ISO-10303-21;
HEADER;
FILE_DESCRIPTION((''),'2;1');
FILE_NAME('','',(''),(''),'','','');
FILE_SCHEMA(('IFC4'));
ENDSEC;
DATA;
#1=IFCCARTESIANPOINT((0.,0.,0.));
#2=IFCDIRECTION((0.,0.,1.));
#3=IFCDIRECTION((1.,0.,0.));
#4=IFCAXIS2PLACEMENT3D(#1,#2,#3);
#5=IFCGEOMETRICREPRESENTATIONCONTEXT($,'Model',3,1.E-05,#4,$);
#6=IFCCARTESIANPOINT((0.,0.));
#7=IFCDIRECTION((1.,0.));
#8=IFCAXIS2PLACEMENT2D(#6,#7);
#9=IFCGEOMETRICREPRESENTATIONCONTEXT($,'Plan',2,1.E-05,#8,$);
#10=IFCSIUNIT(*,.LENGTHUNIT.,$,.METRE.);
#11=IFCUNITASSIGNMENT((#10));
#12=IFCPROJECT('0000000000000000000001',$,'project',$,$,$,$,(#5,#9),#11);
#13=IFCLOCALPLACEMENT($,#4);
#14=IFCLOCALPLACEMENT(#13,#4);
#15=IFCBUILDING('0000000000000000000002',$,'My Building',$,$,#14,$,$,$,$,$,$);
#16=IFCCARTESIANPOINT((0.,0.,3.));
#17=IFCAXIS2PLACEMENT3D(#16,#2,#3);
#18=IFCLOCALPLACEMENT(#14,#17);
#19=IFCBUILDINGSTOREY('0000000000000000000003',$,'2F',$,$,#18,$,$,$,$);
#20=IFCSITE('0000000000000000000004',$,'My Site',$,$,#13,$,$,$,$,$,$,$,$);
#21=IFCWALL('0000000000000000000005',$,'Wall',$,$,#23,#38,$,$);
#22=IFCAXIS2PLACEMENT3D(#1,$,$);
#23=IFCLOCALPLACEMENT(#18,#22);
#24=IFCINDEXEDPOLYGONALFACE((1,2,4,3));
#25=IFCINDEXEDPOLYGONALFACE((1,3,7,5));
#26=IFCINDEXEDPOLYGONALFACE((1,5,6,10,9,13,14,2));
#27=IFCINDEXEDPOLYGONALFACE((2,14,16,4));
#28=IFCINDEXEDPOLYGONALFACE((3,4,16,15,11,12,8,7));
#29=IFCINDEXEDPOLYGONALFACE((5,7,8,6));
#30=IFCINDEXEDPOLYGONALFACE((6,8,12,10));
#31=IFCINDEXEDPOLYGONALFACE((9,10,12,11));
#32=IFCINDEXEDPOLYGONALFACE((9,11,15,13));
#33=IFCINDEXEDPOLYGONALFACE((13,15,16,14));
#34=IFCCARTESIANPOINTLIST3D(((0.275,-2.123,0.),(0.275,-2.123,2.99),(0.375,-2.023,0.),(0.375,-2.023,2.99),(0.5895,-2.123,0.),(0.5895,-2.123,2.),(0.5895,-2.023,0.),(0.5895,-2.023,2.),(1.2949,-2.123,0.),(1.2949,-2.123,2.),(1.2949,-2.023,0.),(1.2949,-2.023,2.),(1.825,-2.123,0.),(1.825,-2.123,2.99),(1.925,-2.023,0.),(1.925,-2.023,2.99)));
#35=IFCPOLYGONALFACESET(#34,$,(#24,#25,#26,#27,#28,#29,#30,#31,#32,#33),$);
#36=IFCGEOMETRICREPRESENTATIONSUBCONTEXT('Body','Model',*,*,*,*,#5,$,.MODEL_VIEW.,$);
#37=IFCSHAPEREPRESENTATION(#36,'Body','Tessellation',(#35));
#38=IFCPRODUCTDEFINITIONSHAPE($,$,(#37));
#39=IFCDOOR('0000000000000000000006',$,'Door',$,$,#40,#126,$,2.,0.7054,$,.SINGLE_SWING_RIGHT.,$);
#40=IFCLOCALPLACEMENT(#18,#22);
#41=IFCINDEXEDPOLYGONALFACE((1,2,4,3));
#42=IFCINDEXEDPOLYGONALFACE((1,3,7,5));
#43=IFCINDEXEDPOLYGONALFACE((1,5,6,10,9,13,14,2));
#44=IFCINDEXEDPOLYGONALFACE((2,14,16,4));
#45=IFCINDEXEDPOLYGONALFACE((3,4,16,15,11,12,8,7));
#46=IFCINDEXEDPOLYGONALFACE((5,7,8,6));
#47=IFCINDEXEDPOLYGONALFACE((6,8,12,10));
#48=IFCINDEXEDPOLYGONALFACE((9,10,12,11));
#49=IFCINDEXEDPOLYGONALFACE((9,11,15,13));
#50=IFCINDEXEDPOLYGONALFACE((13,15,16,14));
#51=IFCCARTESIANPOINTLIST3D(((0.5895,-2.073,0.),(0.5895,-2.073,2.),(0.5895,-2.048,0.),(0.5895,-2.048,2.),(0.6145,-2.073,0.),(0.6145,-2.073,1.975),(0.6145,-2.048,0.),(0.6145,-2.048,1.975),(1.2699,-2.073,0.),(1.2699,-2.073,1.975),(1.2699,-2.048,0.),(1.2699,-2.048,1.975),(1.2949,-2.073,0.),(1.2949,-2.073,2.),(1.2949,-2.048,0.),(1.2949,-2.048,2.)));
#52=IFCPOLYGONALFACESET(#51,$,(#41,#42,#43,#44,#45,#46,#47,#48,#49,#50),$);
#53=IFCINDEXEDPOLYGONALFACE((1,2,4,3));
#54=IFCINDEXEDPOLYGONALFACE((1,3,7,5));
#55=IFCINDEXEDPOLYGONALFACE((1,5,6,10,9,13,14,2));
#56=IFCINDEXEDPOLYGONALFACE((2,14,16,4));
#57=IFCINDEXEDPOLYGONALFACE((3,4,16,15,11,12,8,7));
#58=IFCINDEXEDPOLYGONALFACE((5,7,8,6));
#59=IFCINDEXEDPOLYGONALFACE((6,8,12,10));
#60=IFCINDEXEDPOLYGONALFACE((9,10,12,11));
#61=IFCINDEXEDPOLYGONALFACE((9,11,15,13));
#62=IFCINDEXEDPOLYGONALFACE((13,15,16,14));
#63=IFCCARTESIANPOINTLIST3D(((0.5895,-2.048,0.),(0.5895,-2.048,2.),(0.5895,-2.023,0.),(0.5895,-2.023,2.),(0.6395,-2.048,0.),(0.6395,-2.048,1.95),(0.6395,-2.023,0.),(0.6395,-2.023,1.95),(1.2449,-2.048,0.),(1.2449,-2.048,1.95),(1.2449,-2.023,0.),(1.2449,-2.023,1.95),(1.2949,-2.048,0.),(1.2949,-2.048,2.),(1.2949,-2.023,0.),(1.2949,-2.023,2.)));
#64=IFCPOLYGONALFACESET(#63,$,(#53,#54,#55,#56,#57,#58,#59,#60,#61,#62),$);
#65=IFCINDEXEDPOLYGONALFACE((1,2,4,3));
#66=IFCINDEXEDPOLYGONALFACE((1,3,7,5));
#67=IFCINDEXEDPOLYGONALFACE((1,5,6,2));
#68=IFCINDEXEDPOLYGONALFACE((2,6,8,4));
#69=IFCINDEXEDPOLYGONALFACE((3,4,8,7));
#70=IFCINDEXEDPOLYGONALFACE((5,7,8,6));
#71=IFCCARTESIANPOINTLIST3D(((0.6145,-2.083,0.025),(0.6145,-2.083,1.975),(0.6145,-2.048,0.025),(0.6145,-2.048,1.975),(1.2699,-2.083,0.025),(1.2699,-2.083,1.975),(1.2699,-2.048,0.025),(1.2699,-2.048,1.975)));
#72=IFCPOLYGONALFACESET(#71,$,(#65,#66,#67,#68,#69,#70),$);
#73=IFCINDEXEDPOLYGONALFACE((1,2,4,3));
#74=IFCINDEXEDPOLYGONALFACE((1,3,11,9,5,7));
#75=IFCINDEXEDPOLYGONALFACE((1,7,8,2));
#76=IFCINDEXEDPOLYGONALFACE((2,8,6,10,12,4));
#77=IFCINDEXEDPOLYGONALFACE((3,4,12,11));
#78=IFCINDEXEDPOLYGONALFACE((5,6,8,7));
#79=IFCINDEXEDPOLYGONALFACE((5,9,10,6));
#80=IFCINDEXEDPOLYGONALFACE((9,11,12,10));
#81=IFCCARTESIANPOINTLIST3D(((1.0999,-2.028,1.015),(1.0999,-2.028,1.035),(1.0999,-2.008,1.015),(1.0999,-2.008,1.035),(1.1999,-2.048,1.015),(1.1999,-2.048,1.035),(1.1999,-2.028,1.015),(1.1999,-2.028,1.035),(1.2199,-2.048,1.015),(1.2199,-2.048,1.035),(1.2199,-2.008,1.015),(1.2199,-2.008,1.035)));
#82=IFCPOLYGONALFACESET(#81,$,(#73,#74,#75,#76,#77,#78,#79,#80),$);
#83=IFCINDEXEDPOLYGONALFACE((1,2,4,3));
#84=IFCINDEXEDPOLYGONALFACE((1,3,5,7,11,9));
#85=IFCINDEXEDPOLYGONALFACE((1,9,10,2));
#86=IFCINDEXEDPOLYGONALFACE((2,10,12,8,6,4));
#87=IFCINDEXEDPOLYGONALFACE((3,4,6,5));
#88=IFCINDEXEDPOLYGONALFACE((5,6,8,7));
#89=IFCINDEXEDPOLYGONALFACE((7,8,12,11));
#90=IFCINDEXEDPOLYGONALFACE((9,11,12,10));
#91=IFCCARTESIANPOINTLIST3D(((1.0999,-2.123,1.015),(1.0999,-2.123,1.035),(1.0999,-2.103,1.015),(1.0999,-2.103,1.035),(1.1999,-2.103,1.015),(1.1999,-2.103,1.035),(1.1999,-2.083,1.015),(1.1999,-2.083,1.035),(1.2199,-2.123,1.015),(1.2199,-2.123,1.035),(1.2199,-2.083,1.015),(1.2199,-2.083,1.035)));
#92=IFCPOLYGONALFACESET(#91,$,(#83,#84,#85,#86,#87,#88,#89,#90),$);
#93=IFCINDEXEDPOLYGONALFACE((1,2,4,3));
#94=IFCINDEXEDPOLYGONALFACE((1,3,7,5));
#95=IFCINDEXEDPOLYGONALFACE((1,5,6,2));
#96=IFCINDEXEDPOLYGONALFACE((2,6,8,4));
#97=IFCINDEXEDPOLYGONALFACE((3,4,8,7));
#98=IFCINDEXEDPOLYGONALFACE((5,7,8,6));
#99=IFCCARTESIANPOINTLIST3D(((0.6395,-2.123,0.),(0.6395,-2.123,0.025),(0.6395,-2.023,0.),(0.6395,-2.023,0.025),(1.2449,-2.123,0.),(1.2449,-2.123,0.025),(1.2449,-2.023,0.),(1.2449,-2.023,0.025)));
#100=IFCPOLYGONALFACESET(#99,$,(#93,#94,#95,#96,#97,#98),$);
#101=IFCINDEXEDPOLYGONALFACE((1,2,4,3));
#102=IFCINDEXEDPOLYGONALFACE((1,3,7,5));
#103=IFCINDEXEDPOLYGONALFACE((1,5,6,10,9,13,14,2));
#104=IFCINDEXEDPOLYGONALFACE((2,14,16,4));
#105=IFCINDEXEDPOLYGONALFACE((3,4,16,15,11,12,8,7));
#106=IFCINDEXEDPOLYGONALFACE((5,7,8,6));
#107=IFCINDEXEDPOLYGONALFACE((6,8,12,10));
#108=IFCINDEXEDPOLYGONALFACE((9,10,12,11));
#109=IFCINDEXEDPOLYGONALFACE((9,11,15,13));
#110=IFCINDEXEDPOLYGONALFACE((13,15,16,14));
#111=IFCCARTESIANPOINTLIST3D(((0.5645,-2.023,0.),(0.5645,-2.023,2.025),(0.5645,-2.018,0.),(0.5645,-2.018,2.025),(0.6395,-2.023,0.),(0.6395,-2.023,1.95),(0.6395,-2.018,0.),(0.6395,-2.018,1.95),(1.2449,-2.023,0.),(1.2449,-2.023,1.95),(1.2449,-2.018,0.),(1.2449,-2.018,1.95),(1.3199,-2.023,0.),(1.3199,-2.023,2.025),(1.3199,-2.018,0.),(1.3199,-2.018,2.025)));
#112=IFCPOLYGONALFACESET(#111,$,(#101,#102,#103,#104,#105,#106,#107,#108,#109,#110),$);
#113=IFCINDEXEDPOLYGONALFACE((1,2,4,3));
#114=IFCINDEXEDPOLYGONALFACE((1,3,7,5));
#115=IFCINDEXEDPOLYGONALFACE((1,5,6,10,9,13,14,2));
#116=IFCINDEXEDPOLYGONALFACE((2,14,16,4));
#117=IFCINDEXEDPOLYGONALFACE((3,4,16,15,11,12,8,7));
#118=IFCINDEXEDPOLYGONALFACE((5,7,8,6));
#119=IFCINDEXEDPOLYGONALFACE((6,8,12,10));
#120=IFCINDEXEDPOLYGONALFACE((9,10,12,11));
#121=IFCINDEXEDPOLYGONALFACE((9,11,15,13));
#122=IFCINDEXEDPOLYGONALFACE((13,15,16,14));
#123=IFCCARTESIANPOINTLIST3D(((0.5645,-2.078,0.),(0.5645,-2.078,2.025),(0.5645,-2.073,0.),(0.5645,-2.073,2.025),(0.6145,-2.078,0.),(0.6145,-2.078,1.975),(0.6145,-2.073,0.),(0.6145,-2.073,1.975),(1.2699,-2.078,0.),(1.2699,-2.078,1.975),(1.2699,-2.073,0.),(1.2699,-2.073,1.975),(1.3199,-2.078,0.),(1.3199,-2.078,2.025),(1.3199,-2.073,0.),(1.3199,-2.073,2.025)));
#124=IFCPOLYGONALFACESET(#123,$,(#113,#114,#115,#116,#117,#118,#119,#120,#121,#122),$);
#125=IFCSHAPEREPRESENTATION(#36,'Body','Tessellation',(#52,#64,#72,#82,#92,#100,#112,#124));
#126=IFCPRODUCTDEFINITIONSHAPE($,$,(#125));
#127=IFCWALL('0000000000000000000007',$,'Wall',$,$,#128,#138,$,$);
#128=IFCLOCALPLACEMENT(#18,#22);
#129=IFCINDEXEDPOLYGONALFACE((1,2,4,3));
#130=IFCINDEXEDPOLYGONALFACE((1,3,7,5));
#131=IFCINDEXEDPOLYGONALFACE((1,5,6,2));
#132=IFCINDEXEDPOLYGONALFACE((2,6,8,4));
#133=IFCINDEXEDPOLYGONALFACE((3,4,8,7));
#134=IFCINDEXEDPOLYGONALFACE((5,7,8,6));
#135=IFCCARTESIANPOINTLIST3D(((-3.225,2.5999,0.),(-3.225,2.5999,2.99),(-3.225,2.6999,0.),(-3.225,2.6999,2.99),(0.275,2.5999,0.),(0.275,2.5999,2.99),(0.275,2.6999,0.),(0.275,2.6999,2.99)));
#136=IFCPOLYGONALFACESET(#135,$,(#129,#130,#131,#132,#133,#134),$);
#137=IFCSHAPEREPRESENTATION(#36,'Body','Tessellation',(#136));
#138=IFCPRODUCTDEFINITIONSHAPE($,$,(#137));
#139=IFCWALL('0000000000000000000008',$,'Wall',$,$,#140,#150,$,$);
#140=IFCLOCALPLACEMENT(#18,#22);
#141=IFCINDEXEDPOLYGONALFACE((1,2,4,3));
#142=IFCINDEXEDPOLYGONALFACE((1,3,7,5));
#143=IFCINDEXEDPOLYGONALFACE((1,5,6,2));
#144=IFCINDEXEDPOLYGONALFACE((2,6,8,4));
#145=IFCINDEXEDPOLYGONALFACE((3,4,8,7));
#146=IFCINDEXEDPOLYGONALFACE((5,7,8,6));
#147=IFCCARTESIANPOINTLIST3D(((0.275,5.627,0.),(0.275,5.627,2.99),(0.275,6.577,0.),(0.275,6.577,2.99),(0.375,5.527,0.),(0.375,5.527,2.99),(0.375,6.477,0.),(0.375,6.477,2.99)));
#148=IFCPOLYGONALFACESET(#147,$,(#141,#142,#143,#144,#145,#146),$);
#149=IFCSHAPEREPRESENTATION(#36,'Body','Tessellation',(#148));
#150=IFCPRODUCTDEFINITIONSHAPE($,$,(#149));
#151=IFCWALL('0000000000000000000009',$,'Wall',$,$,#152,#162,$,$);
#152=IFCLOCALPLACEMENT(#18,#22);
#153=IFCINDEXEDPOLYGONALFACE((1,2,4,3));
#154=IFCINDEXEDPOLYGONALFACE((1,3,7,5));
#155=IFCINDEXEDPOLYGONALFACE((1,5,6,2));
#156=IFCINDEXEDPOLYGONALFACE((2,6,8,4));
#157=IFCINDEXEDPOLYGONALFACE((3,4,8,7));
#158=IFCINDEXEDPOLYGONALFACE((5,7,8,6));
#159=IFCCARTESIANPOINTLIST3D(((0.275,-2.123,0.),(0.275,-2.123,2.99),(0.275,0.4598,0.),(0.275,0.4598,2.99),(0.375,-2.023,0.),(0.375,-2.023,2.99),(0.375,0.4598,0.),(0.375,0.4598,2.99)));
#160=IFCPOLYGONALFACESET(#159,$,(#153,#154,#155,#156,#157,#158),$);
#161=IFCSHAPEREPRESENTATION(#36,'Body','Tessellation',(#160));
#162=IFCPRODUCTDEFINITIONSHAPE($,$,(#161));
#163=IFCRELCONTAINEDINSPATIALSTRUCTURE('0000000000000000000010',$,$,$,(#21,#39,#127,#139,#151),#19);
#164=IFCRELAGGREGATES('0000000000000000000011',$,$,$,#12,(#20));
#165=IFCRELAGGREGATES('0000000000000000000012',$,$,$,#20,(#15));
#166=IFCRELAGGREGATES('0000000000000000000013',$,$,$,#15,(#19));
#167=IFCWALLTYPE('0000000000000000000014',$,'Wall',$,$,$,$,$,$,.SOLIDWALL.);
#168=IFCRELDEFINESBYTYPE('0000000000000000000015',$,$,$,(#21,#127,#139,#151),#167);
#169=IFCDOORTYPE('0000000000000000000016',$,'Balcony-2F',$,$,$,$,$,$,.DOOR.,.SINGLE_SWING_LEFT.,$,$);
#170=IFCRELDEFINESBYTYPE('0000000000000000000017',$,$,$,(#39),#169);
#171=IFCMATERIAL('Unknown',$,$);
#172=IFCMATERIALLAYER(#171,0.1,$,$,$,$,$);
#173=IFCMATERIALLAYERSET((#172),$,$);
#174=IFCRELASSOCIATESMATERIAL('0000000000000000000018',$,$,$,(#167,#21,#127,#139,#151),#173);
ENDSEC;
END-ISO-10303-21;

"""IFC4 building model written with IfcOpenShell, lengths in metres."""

from ifc_helpers import new_model, entity, si_unit, frame, origin_with_axes, origin_2d_with_axis, place, context, subcontext, project, spatial, line, indexed_curve, outline, extrude, shape, source, transform, mapped, material, layer, layer_set, layer_usage, type_object, type_shapes, element, fill, save


model = new_model("IFC4")

# Units and contexts
model_context = context("Model", 3, precision=1e-05, world=origin_with_axes())
plan_context = context("Plan", 2, precision=1e-05, world=origin_2d_with_axis())
body_context_1 = subcontext(model_context, "Body", "Model", "MODEL_VIEW")
body_context_2 = subcontext(plan_context, "Body", "Plan", "PLAN_VIEW")
ifc_project = project(units=[si_unit("LENGTHUNIT", "METRE")], contexts=[model_context, plan_context])

# Site, building, storey
site_placement = place(None, origin_with_axes())
site = spatial("IfcSite", under=ifc_project, at=site_placement, Name="My Site")
building_placement = place(site_placement, origin_with_axes())
building = spatial("IfcBuilding", under=site, at=building_placement, Name="My Building")
storey_placement = place(building_placement, frame((0.0, 0.0, 3.0), z_axis=(0.0, 0.0, 1.0), x_axis=(1.0, 0.0, 0.0)))
storey = spatial("IfcBuildingStorey", under=building, at=storey_placement, Name="2F")

# Shared definitions
ifc_material = material(Name="Unknown")

# Shared definitions
ifc_layer_1 = layer(ifc_material, 0.1)
ifc_layer_set_1 = layer_set([ifc_layer_1])
wall_type = type_object("IfcWallType", Name="Wall", PredefinedType="SOLIDWALL", material=ifc_layer_set_1)

# Wall, opening, door
ifc_layer_usage_1 = layer_usage(ifc_layer_set_1, "AXIS2", "POSITIVE", 0.0)
wall_1_placement = place(storey_placement, frame((0.275, -2.123, 0.0), z_axis=(0.0, 0.0, 1.0), x_axis=(1.0, 0.000001, 0.0)))
wall_1 = element("IfcWall", 1, at=wall_1_placement, inside=storey, type_object=wall_type, material=ifc_layer_usage_1, Name="Wall", context=body_context_1, shape_type="SweptSolid", body=[
    extrude(outline(indexed_curve([(0.0, 0.0), (0.1, 0.1), (1.65, 0.1), (1.55, 0.0)], segments=[line(1, 2, 3, 4, 1)])), origin_with_axes(), (0.0, 0.0, 1.0), 2.99),
])
shared_shape_1 = source(origin_with_axes(), body_context_1, "Body", "SweptSolid", [
    extrude(outline(indexed_curve([(0.0, 0.0), (0.7054, 0.0), (0.7054, 2.0), (0.0, 2.0)], segments=[line(1, 2, 3, 4, 1)])), frame((0.0, -0.6, 0.0), z_axis=(0.0, -1.0, 0.0), x_axis=(1.0, 0.0, 0.0)), (0.0, 0.0, -1.0), 1.2),
])
opening_1_placement = place(wall_1_placement, frame((1.0199, 0.1, 0.0), z_axis=(0.0, 0.0, 1.0), x_axis=(-1.0, 0.0, 0.0)))
opening_1 = element("IfcOpeningElement", 2, at=opening_1_placement, cuts=wall_1, PredefinedType="OPENING", context=body_context_1, shape_type="MappedRepresentation", body=[
    mapped(shared_shape_1, transform((0.0, 0.0, 0.0), x_axis=(1.0, 0.0, 0.0), y_axis=(0.0, 1.0, 0.0), z_axis=(0.0, 0.0, 1.0), scale=1.0)),
])
door_type_1 = type_object("IfcDoorType", Name="Balcony-2F", OperationType="SINGLE_SWING_LEFT", PredefinedType="DOOR")
shared_shape_2 = source(origin_with_axes(), body_context_1, "Body", "SweptSolid", [
    extrude(outline(indexed_curve([(0.0, 0.0), (0.0, 2.0), (0.7054, 2.0), (0.7054, 0.0), (0.6804, 0.0), (0.6804, 1.975), (0.025, 1.975), (0.025, 0.0)], segments=[line(1, 2, 3, 4, 5, 6, 7, 8, 1)])), frame((0.0, 0.025, 0.0), z_axis=(0.0, -1.0, 0.0), x_axis=(1.0, 0.0, 0.0)), (0.0, 0.0, -1.0), 0.025),
    extrude(outline(indexed_curve([(0.0, 0.0), (0.0, 2.0), (0.7054, 2.0), (0.7054, 0.0), (0.6554, 0.0), (0.6554, 1.95), (0.05, 1.95), (0.05, 0.0)], segments=[line(1, 2, 3, 4, 5, 6, 7, 8, 1)])), frame((0.0, 0.0, 0.0), z_axis=(0.0, -1.0, 0.0), x_axis=(1.0, 0.0, 0.0)), (0.0, 0.0, -1.0), 0.025),
    extrude(outline(indexed_curve([(0.0, 0.0), (0.6554, 0.0), (0.6554, 0.035), (0.0, 0.035)], segments=[line(1, 2, 3, 4, 1)])), frame((0.025, 0.025, 0.025), z_axis=(0.0, 0.0, 1.0), x_axis=(1.0, 0.0, 0.0)), (0.0, 0.0, 1.0), 1.95),
    extrude(outline(indexed_curve([(0.0, 0.0), (0.0, -0.04), (0.12, -0.04), (0.12, -0.02), (0.02, -0.02), (0.02, 0.0)], segments=[line(1, 2, 3, 4, 5, 6, 1)])), frame((0.075, 0.025, 1.015), z_axis=(0.0, 0.0, 1.0), x_axis=(1.0, 0.0, 0.0)), (0.0, 0.0, 1.0), 0.02),
    extrude(outline(indexed_curve([(0.0, 0.0), (0.0, 0.04), (0.12, 0.04), (0.12, 0.02), (0.02, 0.02), (0.02, 0.0)], segments=[line(1, 2, 3, 4, 5, 6, 1)])), frame((0.075, 0.06, 1.015), z_axis=(0.0, 0.0, 1.0), x_axis=(1.0, 0.0, 0.0)), (0.0, 0.0, 1.0), 0.02),
    extrude(outline(indexed_curve([(0.0, 0.0), (0.6054, 0.0), (0.6054, 0.1), (0.0, 0.1)], segments=[line(1, 2, 3, 4, 1)])), frame((0.05, 0.0, 0.0), z_axis=(0.0, 0.0, 1.0), x_axis=(1.0, 0.0, 0.0)), (0.0, 0.0, 1.0), 0.025),
    extrude(outline(indexed_curve([(0.0, 0.0), (0.0, 2.025), (0.7554, 2.025), (0.7554, 0.0), (0.6804, 0.0), (0.6804, 1.95), (0.075, 1.95), (0.075, 0.0)], segments=[line(1, 2, 3, 4, 5, 6, 7, 8, 1)])), frame((-0.025, -0.005, 0.0), z_axis=(0.0, -1.0, 0.0), x_axis=(1.0, 0.0, 0.0)), (0.0, 0.0, -1.0), 0.005),
    extrude(outline(indexed_curve([(0.0, 0.0), (0.0, 2.025), (0.7554, 2.025), (0.7554, 0.0), (0.7054, 0.0), (0.7054, 1.975), (0.05, 1.975), (0.05, 0.0)], segments=[line(1, 2, 3, 4, 5, 6, 7, 8, 1)])), frame((-0.025, 0.05, 0.0), z_axis=(0.0, -1.0, 0.0), x_axis=(1.0, 0.0, 0.0)), (0.0, 0.0, -1.0), 0.005),
])
shared_shape_3 = source(origin_with_axes(), body_context_2, "Body", "Curve2D", [
    entity("IfcIndexedPolyCurve", entity("IfcCartesianPointList2D", [[0.0, 0.0], [0.0, 0.05], [0.025, 0.05], [0.025, 0.025], [0.05, 0.025], [0.05, 0.0]]), [entity("IfcLineIndex", [1, 2, 3, 4, 5, 6, 1])]),
    entity("IfcIndexedPolyCurve", entity("IfcCartesianPointList2D", [[0.7054, 0.0], [0.7054, 0.05], [0.6804, 0.05], [0.6804, 0.025], [0.6554, 0.025], [0.6554, 0.0]]), [entity("IfcLineIndex", [1, 2, 3, 4, 5, 6, 1])]),
    entity("IfcTrimmedCurve", entity("IfcEllipse", entity("IfcAxis2Placement2D", entity("IfcCartesianPoint", [0.6454, 0.05]), entity("IfcDirection", [1.0, 0.0])), 0.6204, 0.6554), [entity("IfcCartesianPoint", [0.6454, 0.7054])], [entity("IfcCartesianPoint", [0.025, 0.05])], True, "CARTESIAN"),
    entity("IfcIndexedPolyCurve", entity("IfcCartesianPointList2D", [[0.6804, 0.05], [0.6454, 0.05], [0.6454, 0.7054], [0.6804, 0.7054]]), [entity("IfcLineIndex", [1, 2, 3, 4, 1])]),
])
type_shapes(door_type_1, [shared_shape_2, shared_shape_3])
door_1_placement = place(opening_1_placement, frame((0.0, 0.0, 0.0), z_axis=(0.0, 0.0, 1.0), x_axis=(1.0, 0.0, 0.0)))
door_1 = element("IfcDoor", 3, at=door_1_placement, inside=storey, type_object=door_type_1, Name="Door", OperationType="SINGLE_SWING_RIGHT", OverallHeight=2.0, OverallWidth=0.7054, shapes=[
    shape(body_context_1, "Body", "MappedRepresentation", [mapped(shared_shape_2, transform((0.0, 0.0, 0.0), x_axis=(1.0, 0.0, 0.0), y_axis=(0.0, 1.0, 0.0), z_axis=(0.0, 0.0, 1.0), scale=1.0))]),
    shape(body_context_2, "Body", "MappedRepresentation", [mapped(shared_shape_3, transform((0.0, 0.0, 0.0), x_axis=(1.0, 0.0, 0.0), y_axis=(0.0, 1.0, 0.0), z_axis=(0.0, 0.0, 1.0), scale=1.0))]),
])
fill(opening_1, door_1)

# Wall
ifc_layer_usage_2 = layer_usage(ifc_layer_set_1, "AXIS2", "POSITIVE", 0.0)
wall_2_placement = place(storey_placement, frame((-3.225, 2.5999, 0.0), z_axis=(0.0, 0.0, 1.0), x_axis=(1.0, 0.0, 0.0)))
element("IfcWall", 4, at=wall_2_placement, inside=storey, type_object=wall_type, material=ifc_layer_usage_2, Name="Wall", context=body_context_1, shape_type="SweptSolid", body=[
    extrude(outline(indexed_curve([(0.0, 0.0), (0.0, 0.1), (3.5, 0.1), (3.5, 0.0)], segments=[line(1, 2, 3, 4, 1)])), origin_with_axes(), (0.0, 0.0, 1.0), 2.99),
])

# Walls
ifc_layer_usage_3 = layer_usage(ifc_layer_set_1, "AXIS2", "POSITIVE", 0.0)
wall_3_placement = place(storey_placement, frame((0.375, 5.627, 0.0), z_axis=(0.0, 0.0, 1.0), x_axis=(0.0, 1.0, 0.0)))
element("IfcWall", 5, at=wall_3_placement, inside=storey, type_object=wall_type, material=ifc_layer_usage_3, Name="Wall", context=body_context_1, shape_type="SweptSolid", body=[
    extrude(outline(indexed_curve([(-0.1, 0.0), (0.0, 0.1), (0.95, 0.1), (0.85, 0.0)], segments=[line(1, 2, 3, 4, 1)])), origin_with_axes(), (0.0, 0.0, 1.0), 2.99),
])
ifc_layer_usage_4 = layer_usage(ifc_layer_set_1, "AXIS2", "POSITIVE", 0.0)
wall_4_placement = place(storey_placement, frame((0.275, 0.4598, 0.0), z_axis=(0.0, 0.0, 1.0), x_axis=(0.0, -1.0, 0.0)))
element("IfcWall", 6, at=wall_4_placement, inside=storey, type_object=wall_type, material=ifc_layer_usage_4, Name="Wall", context=body_context_1, shape_type="SweptSolid", body=[
    extrude(outline(indexed_curve([(0.0, 0.0), (0.0, 0.1), (2.4828, 0.1), (2.5828, 0.0)], segments=[line(1, 2, 3, 4, 1)])), origin_with_axes(), (0.0, 0.0, 1.0), 2.99),
])

save(model, "model.ifc")
